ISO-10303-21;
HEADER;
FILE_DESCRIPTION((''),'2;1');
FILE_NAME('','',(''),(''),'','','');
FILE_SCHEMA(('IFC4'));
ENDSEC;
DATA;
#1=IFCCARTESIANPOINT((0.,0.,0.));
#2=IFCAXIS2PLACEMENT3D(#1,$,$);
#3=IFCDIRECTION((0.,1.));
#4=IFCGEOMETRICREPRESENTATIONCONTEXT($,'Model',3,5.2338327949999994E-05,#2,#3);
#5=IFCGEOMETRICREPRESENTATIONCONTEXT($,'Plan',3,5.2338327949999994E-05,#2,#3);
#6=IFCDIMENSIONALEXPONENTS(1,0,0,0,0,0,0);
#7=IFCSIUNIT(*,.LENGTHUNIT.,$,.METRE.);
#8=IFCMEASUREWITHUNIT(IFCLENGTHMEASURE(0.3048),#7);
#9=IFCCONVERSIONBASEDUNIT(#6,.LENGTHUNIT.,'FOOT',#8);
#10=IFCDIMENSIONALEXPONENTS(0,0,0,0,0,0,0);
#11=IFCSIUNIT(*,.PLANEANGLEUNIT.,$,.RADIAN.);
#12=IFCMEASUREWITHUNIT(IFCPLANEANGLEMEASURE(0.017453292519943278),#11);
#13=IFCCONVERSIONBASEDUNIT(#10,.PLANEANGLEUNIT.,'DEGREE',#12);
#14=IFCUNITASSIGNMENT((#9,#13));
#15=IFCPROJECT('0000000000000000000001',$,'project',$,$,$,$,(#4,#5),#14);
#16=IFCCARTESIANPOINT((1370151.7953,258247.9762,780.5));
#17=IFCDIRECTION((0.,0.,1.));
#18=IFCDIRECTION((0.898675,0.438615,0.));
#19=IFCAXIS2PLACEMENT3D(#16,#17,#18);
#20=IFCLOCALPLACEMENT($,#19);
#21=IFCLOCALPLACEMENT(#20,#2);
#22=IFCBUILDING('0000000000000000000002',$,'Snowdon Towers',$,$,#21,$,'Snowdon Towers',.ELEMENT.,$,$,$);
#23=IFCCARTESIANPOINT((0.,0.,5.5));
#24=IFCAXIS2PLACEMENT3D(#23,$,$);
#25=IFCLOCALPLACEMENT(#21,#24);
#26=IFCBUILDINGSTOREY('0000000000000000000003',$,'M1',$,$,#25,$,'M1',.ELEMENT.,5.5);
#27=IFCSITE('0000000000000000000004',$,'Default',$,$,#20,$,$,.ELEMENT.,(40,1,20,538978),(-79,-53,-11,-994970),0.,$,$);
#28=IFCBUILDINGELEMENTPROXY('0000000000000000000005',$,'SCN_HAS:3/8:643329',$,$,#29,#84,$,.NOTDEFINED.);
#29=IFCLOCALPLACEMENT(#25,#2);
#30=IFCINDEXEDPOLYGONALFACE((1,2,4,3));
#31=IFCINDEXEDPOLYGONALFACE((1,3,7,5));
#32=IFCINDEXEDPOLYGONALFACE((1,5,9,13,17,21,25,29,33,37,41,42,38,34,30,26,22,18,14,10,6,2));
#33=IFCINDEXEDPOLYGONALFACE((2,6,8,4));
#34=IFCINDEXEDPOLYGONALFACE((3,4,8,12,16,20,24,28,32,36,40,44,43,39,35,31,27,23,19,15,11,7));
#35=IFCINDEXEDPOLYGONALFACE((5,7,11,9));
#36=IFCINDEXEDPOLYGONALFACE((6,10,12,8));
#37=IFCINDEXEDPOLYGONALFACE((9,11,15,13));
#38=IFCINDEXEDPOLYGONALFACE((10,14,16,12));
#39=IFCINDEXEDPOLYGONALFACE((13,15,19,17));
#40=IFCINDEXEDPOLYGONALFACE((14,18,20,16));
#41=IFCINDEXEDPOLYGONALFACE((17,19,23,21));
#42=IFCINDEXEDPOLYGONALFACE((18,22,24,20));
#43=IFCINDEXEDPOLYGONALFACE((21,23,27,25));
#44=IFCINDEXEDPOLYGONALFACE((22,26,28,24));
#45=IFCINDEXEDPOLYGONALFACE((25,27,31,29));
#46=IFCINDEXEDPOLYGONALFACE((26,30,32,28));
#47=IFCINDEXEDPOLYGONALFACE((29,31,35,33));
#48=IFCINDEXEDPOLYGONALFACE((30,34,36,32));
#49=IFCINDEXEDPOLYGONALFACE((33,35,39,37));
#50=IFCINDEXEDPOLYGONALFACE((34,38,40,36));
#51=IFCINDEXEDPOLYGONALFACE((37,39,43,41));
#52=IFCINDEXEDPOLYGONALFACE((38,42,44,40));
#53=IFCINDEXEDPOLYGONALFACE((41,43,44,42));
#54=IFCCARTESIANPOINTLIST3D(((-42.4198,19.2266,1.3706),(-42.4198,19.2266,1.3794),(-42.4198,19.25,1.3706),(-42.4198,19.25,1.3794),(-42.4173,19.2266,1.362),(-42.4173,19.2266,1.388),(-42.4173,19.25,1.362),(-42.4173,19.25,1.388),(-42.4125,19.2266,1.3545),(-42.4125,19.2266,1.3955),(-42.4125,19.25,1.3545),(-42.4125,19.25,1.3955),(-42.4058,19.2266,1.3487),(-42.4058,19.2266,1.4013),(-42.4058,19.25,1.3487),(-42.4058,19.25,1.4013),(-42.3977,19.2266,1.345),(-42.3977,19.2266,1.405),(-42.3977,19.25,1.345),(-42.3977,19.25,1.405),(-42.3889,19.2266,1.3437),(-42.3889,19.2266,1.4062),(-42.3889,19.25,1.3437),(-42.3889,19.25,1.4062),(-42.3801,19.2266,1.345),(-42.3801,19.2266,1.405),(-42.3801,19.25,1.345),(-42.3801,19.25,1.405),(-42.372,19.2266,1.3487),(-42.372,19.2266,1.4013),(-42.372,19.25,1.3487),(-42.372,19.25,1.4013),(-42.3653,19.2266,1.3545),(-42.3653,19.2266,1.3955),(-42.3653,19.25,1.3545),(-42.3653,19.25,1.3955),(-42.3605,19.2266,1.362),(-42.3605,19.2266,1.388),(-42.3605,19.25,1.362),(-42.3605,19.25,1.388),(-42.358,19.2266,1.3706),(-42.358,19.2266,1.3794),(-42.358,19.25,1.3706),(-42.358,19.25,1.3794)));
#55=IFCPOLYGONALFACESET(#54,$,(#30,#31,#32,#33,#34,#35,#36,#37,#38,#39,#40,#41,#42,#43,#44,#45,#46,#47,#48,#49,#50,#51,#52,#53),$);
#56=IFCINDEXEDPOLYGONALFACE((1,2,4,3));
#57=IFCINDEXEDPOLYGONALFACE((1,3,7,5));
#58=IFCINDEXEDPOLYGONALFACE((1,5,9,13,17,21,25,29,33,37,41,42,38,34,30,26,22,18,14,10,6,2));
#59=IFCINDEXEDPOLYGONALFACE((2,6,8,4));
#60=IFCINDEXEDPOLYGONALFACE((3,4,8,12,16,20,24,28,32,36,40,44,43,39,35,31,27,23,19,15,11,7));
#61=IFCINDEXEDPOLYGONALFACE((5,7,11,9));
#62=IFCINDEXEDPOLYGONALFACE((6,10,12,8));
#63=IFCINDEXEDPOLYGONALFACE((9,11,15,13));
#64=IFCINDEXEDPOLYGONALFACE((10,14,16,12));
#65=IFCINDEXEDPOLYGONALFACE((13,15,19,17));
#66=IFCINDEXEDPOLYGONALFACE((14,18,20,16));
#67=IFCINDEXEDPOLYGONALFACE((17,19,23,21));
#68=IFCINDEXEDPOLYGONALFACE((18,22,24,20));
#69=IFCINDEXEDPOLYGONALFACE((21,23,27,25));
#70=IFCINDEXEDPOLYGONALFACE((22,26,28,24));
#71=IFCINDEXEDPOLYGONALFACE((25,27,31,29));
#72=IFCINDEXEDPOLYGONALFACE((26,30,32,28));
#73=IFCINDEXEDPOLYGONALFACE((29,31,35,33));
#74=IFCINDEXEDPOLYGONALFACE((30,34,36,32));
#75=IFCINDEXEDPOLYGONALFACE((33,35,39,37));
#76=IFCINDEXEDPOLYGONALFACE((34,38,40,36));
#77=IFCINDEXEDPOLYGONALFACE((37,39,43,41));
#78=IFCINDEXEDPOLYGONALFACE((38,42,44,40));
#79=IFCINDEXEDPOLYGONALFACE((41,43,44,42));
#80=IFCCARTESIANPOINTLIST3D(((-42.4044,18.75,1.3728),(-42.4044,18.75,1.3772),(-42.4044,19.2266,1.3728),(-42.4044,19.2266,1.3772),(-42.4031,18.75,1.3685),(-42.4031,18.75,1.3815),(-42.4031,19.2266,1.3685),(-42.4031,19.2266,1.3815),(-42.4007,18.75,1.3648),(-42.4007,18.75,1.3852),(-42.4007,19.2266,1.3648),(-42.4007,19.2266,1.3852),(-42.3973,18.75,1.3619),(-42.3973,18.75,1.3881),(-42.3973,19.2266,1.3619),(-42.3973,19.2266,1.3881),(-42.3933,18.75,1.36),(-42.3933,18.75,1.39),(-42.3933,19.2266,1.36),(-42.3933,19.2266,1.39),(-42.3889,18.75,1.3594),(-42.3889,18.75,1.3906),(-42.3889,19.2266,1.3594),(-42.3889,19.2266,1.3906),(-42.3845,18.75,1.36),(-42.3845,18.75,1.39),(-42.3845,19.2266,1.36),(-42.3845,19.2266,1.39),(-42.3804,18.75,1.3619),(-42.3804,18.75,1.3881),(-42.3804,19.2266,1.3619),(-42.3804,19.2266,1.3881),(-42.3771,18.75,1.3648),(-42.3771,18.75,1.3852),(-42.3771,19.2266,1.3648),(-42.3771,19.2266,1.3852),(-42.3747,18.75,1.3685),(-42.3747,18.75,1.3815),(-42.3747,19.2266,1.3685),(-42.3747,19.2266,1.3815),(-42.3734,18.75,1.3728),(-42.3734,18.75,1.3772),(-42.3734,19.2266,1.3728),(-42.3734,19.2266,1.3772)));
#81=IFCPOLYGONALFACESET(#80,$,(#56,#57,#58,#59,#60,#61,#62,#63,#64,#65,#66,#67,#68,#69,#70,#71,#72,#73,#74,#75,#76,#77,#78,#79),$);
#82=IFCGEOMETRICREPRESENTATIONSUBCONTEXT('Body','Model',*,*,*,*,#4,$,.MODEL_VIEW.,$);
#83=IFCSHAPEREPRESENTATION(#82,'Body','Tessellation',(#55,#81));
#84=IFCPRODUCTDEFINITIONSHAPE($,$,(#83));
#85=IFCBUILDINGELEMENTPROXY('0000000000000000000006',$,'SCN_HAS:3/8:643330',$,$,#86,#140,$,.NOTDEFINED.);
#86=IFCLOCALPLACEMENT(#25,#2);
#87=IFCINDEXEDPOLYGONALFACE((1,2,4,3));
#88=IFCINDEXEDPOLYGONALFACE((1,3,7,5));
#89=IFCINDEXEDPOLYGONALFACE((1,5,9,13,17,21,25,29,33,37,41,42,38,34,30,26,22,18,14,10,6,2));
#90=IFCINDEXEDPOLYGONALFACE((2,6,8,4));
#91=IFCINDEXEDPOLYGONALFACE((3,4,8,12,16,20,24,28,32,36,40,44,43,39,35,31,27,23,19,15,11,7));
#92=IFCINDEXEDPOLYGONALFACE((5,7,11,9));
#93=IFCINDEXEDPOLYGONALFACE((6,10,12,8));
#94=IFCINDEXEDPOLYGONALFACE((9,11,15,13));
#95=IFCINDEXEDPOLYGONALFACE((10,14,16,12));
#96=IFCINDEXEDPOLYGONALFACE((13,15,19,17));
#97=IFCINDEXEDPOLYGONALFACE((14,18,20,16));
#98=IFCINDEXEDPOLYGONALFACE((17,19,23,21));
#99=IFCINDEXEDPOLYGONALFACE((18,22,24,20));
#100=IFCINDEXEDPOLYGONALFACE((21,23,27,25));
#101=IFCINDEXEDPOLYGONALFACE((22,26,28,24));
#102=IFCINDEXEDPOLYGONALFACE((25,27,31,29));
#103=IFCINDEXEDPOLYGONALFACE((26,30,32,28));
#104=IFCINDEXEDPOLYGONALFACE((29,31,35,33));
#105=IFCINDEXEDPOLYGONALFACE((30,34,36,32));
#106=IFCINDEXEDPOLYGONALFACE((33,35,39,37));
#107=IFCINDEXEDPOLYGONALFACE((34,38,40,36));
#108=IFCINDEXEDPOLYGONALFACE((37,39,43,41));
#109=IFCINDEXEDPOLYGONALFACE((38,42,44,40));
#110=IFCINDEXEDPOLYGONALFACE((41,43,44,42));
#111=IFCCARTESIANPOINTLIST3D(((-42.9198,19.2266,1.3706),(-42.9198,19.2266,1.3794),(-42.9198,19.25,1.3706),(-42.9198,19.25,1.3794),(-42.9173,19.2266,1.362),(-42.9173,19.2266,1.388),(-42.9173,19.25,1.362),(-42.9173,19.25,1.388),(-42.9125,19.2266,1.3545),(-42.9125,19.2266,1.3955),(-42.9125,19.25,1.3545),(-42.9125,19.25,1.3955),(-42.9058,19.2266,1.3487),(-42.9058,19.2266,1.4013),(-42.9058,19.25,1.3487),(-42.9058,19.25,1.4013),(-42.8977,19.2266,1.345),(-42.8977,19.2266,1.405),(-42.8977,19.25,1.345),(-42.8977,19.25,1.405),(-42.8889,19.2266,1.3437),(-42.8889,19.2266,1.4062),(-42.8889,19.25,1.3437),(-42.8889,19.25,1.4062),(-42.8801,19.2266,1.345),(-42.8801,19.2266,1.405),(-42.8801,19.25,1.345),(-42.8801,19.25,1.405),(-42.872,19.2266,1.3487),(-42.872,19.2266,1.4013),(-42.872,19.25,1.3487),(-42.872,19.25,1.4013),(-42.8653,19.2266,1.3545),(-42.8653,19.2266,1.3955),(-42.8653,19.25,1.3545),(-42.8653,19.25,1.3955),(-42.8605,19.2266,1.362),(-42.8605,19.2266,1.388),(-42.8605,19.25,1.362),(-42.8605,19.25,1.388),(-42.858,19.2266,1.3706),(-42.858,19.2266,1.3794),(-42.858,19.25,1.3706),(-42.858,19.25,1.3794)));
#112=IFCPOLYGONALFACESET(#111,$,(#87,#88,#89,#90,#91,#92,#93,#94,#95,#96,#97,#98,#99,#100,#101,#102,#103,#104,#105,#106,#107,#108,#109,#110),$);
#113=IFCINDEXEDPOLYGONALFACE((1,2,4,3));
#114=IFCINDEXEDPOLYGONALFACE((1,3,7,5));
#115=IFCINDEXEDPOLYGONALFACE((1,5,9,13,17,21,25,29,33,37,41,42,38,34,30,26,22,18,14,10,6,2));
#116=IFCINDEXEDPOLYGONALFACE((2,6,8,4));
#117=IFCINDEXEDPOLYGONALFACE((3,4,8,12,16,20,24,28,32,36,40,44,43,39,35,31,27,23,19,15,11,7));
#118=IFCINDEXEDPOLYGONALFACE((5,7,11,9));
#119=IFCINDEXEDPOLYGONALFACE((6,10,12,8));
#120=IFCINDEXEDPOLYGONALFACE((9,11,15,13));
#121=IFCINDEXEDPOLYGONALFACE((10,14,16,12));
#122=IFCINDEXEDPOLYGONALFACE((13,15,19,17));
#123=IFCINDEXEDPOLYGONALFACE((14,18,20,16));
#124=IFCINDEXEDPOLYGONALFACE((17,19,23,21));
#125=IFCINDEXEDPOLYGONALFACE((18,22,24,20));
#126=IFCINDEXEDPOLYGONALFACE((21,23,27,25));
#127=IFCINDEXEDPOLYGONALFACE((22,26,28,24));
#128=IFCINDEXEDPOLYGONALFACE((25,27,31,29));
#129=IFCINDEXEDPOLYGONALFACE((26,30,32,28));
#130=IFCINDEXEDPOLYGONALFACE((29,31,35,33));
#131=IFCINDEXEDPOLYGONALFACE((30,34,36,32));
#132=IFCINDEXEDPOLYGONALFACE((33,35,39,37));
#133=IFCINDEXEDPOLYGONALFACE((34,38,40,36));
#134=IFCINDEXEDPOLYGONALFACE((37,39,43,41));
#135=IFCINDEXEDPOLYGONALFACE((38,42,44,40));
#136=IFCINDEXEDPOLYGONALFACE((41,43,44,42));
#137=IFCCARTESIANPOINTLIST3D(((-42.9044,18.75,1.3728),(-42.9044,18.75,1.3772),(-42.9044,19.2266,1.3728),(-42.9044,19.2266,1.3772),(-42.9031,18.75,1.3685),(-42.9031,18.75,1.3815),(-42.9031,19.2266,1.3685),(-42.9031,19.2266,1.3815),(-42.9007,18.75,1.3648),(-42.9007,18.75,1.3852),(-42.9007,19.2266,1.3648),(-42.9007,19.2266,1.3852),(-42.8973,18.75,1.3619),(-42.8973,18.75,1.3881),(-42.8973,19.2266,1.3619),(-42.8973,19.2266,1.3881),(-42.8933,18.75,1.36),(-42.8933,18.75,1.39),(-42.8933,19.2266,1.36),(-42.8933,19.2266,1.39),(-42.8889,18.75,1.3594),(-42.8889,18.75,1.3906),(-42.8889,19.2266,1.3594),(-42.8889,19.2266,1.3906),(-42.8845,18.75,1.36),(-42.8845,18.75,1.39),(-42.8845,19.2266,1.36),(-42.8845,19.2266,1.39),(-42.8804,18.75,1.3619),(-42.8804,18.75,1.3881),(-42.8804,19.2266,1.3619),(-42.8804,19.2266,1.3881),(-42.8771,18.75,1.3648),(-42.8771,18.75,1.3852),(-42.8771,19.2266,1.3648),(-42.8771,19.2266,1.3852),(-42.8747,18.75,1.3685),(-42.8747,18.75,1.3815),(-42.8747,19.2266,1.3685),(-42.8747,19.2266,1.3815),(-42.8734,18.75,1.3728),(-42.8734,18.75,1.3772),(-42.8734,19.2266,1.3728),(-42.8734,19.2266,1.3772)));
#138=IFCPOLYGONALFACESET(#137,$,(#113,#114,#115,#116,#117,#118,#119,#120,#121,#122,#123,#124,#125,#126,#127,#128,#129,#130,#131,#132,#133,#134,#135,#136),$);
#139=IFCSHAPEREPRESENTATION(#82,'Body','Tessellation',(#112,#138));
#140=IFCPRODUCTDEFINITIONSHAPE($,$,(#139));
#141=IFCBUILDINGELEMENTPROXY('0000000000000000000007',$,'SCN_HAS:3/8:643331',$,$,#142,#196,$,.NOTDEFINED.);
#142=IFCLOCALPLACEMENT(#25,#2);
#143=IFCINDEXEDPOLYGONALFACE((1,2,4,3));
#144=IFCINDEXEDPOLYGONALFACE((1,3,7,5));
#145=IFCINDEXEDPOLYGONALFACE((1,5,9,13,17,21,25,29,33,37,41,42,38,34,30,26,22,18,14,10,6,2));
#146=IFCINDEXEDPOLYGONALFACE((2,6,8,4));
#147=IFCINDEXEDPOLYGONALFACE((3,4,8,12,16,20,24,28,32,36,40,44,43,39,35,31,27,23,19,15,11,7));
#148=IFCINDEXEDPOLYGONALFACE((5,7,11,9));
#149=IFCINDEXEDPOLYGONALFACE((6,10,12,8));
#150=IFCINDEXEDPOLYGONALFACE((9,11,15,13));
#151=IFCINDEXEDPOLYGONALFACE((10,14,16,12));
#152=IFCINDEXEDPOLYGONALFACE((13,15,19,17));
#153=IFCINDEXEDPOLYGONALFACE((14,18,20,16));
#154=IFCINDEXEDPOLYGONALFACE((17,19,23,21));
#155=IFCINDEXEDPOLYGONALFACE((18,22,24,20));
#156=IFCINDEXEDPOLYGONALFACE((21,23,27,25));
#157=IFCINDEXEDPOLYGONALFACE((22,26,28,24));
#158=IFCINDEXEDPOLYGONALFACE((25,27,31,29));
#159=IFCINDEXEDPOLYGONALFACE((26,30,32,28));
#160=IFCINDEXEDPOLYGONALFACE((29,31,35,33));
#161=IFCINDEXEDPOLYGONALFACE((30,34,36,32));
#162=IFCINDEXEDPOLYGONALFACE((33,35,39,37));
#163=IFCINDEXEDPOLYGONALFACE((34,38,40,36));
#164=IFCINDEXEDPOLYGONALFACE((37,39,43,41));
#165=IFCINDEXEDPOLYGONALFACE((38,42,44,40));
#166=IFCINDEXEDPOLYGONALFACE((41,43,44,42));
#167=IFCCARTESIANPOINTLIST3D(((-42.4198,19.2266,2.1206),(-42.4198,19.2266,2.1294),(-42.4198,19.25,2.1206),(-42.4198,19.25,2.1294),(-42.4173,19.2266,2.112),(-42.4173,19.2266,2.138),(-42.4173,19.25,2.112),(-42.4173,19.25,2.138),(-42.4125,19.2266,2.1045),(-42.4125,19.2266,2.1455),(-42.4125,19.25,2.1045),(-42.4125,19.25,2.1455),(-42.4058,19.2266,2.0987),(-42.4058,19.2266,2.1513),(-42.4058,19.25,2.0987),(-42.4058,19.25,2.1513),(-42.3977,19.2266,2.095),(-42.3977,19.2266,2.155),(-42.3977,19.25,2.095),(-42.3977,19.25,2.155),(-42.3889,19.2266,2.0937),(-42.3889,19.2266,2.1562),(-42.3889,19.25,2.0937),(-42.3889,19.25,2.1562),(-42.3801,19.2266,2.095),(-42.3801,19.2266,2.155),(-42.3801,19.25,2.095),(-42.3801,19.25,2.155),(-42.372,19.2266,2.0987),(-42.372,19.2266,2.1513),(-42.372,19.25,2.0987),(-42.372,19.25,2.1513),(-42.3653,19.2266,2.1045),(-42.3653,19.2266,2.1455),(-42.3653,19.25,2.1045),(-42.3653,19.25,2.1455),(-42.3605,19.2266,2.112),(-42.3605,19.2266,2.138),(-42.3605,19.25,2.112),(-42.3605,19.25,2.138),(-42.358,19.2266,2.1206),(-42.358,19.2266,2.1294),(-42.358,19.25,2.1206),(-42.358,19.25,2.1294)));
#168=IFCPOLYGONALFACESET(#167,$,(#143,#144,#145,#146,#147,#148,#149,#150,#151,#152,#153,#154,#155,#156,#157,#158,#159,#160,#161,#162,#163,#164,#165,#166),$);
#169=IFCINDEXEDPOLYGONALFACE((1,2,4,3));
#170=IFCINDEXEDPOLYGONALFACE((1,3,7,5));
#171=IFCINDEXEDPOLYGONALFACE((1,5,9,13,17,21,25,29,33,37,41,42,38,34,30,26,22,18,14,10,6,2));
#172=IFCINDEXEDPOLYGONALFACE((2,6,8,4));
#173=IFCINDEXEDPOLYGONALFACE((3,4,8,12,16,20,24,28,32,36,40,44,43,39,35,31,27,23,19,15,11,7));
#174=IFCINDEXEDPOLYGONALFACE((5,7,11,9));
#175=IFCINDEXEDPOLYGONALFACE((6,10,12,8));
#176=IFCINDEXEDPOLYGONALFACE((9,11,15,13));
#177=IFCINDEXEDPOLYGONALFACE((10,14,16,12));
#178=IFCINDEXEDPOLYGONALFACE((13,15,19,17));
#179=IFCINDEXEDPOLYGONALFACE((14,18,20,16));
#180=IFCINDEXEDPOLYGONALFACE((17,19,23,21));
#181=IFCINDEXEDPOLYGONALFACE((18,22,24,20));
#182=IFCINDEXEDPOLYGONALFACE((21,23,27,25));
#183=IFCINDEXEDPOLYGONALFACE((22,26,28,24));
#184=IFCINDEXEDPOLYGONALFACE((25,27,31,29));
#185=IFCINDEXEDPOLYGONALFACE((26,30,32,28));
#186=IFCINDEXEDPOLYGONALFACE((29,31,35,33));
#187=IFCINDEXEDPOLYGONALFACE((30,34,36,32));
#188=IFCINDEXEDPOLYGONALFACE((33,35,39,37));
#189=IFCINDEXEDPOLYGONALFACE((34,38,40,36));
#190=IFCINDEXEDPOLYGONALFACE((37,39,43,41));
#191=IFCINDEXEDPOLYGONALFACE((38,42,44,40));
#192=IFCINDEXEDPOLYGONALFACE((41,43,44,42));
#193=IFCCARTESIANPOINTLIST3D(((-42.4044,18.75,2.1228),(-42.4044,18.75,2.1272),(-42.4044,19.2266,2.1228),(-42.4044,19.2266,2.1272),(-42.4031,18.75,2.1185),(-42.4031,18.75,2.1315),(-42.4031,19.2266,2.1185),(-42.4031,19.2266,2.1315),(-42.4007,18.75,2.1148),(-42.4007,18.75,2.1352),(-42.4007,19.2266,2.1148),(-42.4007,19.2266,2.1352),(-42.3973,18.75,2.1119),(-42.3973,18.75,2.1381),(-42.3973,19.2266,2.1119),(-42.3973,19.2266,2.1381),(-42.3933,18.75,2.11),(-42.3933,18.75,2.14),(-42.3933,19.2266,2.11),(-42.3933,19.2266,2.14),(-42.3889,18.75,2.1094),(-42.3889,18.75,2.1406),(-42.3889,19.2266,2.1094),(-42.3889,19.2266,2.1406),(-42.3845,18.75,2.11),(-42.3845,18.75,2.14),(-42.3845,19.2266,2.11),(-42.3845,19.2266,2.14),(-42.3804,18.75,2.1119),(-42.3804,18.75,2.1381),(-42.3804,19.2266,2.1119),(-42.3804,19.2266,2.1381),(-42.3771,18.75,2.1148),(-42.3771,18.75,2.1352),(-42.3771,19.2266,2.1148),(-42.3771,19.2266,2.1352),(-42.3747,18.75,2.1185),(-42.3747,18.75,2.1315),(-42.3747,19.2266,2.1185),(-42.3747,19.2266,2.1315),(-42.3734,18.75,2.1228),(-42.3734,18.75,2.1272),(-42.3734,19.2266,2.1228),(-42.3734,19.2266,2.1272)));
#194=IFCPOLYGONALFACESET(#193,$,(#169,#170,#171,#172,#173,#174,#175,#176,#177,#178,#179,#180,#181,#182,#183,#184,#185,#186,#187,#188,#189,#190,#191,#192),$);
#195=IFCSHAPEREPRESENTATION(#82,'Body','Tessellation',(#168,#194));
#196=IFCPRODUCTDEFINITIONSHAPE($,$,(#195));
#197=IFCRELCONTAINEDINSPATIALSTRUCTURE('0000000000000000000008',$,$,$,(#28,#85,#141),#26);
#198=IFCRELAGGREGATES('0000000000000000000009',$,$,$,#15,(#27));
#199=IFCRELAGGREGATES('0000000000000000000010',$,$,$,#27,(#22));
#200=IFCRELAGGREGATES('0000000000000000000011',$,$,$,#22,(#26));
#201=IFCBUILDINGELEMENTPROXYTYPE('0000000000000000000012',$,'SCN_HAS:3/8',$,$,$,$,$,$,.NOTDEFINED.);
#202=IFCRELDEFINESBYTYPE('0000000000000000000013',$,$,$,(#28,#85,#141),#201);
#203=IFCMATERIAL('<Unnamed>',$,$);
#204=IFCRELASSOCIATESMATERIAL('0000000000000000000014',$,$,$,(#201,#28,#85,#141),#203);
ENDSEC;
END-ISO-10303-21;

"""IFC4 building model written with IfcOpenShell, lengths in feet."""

from ifc_helpers import new_model, entity, si_unit, converted_unit, direction, frame, origin, place, context, subcontext, project, spatial, arc, indexed_curve, outline, extrude, source, transform, mapped, material, type_object, type_shapes, element, save


model = new_model("IFC4")

# Units and contexts
model_context = context("Model", 3, precision=5.2338327949999994e-05, world=origin(), true_north=direction((0.0, 1.0)))
plan_context = context("Plan", 3, precision=5.2338327949999994e-05, world=origin(), true_north=direction((0.0, 1.0)))
body_context = subcontext(model_context, "Body", "Model", "MODEL_VIEW")
ifc_project = project(units=[converted_unit("LENGTHUNIT", "FOOT", entity("IfcLengthMeasure", 0.3048), si_unit("LENGTHUNIT", "METRE"), dimensions=[1, 0, 0, 0, 0, 0, 0]), converted_unit("PLANEANGLEUNIT", "DEGREE", entity("IfcPlaneAngleMeasure", 0.017453292519943278), si_unit("PLANEANGLEUNIT", "RADIAN"), dimensions=[0, 0, 0, 0, 0, 0, 0])], contexts=[model_context, plan_context])

# Site, building, storey
site_placement = place(None, frame((1370151.7953, 258247.9762, 780.5), z_axis=(0.0, 0.0, 1.0), x_axis=(0.898675, 0.438615, 0.0)))
site = spatial("IfcSite", under=ifc_project, at=site_placement, Name="Default", CompositionType="ELEMENT", RefLatitude=(40, 1, 20, 538978), RefLongitude=(-79, -53, -11, -994970), RefElevation=0.0)
building_placement = place(site_placement, origin())
building = spatial("IfcBuilding", under=site, at=building_placement, Name="Snowdon Towers", LongName="Snowdon Towers", CompositionType="ELEMENT")
storey_placement = place(building_placement, frame((0.0, 0.0, 5.5)))
storey = spatial("IfcBuildingStorey", under=building, at=storey_placement, Name="M1", LongName="M1", CompositionType="ELEMENT", Elevation=5.5)

# Building element proxies
ifc_material_1 = material(Name="<Unnamed>")
building_element_proxy_type = type_object("IfcBuildingElementProxyType", Name="SCN_HAS:3/8", PredefinedType="NOTDEFINED", material=ifc_material_1)
shared_shape_1 = source(origin(), body_context, "Body", "SweptSolid", [
    extrude(outline(indexed_curve([(-0.0312, 0.0), (0.0, -0.0313), (0.0312, 0.0), (0.0, 0.0312)], segments=[arc(1, 2, 3), arc(3, 4, 1)], self_intersect=False)), frame((0.0, 0.0, -0.5), z_axis=(0.0, 0.0, 1.0), x_axis=(0.0, -1.0, 0.0)), (0.0, 0.0, 1.0), 0.0234),
    extrude(outline(indexed_curve([(-0.0156, 0.0), (0.0, -0.0156), (0.0156, 0.0), (0.0, 0.0156)], segments=[arc(1, 2, 3), arc(3, 4, 1)], self_intersect=False)), frame((0.0, 0.0, -0.4766), z_axis=(0.0, 0.0, 1.0), x_axis=(0.0, -1.0, 0.0)), (0.0, 0.0, 1.0), 0.4766),
])
type_shapes(building_element_proxy_type, [shared_shape_1])
for number, where, z_axis, x_axis, name in (
    (1, (-42.3889, 18.75, 1.375), (0.0, -1.0, 0.0), (1.0, 0.0, 0.0), "SCN_HAS:3/8:643329"),
    (2, (-42.8889, 18.75, 1.375), (0.0, -1.0, 0.0), (1.0, 0.0, 0.0), "SCN_HAS:3/8:643330"),
    (3, (-42.3889, 18.75, 2.125), (0.0, -1.0, 0.0), (1.0, 0.0, 0.0), "SCN_HAS:3/8:643331"),
):
    element("IfcBuildingElementProxy", number, at=place(storey_placement, frame(where, z_axis=z_axis, x_axis=x_axis)), inside=storey, type_object=building_element_proxy_type, material=ifc_material_1, Name=name, PredefinedType="NOTDEFINED", context=body_context, shape_type="MappedRepresentation", body=[
        mapped(shared_shape_1, transform((0.0, 0.0, 0.0), scale=1.0)),
    ])

save(model, "model.ifc")
